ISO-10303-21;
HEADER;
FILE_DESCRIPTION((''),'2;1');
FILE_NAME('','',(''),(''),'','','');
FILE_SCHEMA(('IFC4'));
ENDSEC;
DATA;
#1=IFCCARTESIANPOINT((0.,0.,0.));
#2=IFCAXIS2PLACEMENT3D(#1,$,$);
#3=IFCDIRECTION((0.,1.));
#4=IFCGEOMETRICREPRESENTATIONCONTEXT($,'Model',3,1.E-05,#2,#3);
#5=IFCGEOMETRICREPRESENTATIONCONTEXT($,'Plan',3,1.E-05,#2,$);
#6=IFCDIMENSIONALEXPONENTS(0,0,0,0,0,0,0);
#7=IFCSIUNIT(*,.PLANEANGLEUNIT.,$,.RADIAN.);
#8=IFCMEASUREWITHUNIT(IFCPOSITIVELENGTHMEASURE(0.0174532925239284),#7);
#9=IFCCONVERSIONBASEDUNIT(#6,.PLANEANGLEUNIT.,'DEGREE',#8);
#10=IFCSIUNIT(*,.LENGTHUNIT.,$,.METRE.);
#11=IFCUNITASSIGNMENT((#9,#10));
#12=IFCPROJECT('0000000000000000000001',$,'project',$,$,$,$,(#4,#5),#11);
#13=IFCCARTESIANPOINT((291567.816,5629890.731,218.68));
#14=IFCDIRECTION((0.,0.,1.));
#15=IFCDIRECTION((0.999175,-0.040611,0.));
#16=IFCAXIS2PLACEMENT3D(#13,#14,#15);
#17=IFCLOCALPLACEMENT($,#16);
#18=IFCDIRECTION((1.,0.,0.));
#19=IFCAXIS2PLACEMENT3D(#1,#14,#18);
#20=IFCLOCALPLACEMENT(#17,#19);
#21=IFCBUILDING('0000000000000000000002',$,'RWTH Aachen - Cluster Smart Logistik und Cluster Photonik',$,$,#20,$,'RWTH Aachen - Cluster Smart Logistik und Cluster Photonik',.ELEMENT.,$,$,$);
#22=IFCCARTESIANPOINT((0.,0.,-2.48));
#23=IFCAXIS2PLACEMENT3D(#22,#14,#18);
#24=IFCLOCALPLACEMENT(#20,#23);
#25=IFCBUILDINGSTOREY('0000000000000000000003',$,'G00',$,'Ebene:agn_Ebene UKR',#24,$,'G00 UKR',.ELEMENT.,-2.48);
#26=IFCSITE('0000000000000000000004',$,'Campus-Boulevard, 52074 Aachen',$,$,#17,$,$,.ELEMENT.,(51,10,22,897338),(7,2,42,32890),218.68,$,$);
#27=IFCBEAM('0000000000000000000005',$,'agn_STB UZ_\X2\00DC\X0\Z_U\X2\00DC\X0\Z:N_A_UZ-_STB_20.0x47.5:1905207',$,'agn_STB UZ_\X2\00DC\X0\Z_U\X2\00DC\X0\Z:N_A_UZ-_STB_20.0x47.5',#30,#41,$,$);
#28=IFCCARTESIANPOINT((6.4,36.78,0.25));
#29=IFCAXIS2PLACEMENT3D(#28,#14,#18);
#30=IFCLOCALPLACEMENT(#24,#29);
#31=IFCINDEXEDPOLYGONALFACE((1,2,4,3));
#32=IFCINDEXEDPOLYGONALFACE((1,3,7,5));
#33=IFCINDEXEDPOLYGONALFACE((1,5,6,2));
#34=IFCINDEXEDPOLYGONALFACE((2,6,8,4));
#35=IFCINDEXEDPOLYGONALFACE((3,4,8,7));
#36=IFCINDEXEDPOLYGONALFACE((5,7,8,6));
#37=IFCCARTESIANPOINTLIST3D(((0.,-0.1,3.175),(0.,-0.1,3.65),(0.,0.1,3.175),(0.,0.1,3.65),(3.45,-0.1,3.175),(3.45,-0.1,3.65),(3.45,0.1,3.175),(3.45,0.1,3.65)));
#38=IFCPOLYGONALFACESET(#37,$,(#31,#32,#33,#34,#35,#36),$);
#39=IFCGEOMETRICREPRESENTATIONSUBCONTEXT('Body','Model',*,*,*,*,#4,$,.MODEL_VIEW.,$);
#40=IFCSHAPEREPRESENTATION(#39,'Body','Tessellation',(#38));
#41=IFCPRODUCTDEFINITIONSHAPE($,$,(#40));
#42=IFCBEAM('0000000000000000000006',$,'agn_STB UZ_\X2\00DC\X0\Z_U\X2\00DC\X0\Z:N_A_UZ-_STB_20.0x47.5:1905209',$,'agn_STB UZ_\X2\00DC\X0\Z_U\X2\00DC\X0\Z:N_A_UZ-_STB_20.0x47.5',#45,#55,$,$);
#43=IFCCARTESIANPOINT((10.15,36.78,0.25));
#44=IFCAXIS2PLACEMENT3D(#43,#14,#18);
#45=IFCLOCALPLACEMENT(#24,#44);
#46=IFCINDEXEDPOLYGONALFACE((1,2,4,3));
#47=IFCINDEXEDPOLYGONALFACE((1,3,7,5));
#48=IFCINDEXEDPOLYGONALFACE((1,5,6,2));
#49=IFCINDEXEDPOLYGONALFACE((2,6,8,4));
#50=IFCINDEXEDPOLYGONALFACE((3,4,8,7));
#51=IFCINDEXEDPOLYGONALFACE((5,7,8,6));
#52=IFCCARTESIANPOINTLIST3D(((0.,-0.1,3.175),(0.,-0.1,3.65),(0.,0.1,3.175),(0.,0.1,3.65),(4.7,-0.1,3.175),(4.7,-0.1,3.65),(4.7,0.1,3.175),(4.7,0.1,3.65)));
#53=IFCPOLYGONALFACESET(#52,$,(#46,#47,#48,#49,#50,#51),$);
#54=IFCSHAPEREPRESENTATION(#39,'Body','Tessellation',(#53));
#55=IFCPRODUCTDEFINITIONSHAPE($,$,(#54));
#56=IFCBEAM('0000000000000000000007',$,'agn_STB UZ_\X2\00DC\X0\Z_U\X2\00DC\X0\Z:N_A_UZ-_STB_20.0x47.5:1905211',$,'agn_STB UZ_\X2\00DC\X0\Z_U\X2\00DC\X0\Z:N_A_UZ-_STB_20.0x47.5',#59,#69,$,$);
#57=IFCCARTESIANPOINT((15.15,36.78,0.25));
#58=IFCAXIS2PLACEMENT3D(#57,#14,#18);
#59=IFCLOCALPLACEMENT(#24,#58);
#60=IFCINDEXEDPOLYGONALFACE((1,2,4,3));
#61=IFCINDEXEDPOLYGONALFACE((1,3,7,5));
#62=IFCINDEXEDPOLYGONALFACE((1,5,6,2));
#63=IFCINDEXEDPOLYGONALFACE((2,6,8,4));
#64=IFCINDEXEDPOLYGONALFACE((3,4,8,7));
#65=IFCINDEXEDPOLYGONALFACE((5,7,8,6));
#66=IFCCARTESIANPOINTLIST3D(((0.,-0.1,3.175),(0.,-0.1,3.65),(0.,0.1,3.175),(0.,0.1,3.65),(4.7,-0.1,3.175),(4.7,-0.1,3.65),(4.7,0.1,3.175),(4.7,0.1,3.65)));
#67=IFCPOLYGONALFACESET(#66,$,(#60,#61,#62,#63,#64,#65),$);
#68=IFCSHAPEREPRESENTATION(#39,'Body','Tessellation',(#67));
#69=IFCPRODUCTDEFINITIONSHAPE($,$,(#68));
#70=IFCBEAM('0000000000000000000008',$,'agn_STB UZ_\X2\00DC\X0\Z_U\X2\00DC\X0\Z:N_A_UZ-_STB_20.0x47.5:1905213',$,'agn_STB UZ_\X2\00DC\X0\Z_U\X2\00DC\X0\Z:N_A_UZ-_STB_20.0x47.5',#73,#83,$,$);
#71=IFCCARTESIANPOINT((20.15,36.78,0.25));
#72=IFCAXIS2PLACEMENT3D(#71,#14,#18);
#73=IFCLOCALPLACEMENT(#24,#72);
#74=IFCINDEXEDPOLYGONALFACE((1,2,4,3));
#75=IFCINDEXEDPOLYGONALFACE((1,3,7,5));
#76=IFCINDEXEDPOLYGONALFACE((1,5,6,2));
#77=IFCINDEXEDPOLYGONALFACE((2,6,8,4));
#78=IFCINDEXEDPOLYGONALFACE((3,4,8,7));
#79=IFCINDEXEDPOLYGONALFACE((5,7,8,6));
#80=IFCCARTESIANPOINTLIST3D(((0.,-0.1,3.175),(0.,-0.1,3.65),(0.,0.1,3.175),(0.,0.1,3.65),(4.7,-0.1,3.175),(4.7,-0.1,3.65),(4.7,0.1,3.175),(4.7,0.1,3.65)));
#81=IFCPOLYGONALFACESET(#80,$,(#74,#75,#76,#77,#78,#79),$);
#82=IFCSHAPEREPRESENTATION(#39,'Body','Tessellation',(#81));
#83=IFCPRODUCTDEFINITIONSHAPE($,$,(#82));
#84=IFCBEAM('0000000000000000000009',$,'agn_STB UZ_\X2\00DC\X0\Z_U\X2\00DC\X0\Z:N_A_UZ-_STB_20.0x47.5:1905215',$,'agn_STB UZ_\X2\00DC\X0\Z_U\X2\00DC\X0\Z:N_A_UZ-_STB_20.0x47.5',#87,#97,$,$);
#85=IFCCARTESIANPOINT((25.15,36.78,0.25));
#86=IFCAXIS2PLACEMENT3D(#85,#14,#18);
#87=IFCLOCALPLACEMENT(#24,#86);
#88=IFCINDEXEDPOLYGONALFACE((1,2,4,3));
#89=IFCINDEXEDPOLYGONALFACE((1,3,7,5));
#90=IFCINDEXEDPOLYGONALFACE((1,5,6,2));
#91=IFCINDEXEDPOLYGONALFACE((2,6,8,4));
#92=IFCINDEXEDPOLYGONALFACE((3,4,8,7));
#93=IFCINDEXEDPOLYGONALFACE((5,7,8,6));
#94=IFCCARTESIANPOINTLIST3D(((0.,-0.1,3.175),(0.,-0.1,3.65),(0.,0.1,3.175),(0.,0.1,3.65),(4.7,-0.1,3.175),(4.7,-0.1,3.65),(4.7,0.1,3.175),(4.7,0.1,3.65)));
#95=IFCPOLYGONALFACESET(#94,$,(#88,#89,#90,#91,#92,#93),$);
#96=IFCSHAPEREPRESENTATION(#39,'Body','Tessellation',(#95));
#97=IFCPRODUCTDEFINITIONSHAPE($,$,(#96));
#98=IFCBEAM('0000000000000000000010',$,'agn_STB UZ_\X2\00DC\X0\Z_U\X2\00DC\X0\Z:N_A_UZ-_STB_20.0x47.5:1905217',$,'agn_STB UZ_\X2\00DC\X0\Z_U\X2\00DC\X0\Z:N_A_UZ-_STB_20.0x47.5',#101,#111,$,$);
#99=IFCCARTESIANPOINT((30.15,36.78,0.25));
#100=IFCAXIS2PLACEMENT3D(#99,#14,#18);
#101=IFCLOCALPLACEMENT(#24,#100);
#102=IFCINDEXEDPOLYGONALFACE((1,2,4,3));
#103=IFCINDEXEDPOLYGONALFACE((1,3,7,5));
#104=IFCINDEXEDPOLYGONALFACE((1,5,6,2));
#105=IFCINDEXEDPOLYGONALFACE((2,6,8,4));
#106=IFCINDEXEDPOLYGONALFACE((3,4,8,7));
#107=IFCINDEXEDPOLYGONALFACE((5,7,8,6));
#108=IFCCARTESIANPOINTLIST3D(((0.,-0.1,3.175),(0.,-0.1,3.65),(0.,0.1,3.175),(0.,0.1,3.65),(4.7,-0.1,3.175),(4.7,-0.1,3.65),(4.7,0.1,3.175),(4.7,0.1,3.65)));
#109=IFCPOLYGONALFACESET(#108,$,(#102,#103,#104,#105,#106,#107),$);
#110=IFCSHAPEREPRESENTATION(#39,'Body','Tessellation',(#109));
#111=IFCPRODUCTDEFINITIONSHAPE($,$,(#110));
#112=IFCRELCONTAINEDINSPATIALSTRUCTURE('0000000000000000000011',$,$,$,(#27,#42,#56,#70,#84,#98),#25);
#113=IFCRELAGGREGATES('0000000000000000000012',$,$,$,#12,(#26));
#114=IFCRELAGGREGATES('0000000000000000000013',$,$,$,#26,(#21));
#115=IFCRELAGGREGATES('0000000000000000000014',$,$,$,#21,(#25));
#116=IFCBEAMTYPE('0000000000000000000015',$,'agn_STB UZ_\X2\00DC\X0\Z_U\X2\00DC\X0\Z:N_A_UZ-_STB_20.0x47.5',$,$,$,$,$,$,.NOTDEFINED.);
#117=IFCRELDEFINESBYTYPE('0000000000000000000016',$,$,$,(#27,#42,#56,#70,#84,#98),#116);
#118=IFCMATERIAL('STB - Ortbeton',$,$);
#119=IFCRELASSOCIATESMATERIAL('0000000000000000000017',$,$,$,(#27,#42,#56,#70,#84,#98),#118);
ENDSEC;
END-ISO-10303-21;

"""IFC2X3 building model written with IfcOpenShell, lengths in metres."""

from ifc_helpers import new_model, entity, si_unit, converted_unit, direction, frame, frame_2d, origin, origin_with_axes, place, context, subcontext, project, spatial, rectangle, extrude, material, type_object, element, save


model = new_model("IFC2X3")

# Units and contexts
model_context = context("Model", 3, precision=1e-05, world=origin(), true_north=direction((0.0, 1.0)))
plan_context = context("Plan", 3, precision=1e-05, world=origin())
body_context = subcontext(model_context, "Body", "Model", "MODEL_VIEW")
ifc_project = project(units=[converted_unit("PLANEANGLEUNIT", "DEGREE", entity("IfcPositiveLengthMeasure", 0.0174532925239284), si_unit("PLANEANGLEUNIT", "RADIAN"), dimensions=[0, 0, 0, 0, 0, 0, 0]), si_unit("LENGTHUNIT", "METRE")], contexts=[model_context, plan_context])

# Site, building, storey
site_placement = place(None, frame((291567.816, 5629890.731, 218.68), z_axis=(0.0, 0.0, 1.0), x_axis=(0.999175, -0.040611, 0.0)))
site = spatial("IfcSite", under=ifc_project, at=site_placement, Name="Campus-Boulevard, 52074 Aachen", CompositionType="ELEMENT", RefLatitude=(51, 10, 22, 897338), RefLongitude=(7, 2, 42, 32890), RefElevation=218.68)
building_placement = place(site_placement, origin_with_axes())
building = spatial("IfcBuilding", under=site, at=building_placement, Name="RWTH Aachen - Cluster Smart Logistik und Cluster Photonik", LongName="RWTH Aachen - Cluster Smart Logistik und Cluster Photonik", CompositionType="ELEMENT")
storey_placement = place(building_placement, frame((0.0, 0.0, -2.48), z_axis=(0.0, 0.0, 1.0), x_axis=(1.0, 0.0, 0.0)))
storey = spatial("IfcBuildingStorey", under=building, at=storey_placement, Name="G00", ObjectType="Ebene:agn_Ebene UKR", LongName="G00 UKR", CompositionType="ELEMENT", Elevation=-2.48)

# Beams
ifc_material_1 = material(Name="STB - Ortbeton")
beam_type_1 = type_object("IfcBeamType", Name="agn_STB UZ_ÜZ_UÜZ:N_A_UZ-_STB_20.0x47.5", PredefinedType="NOTDEFINED")
beam_1_placement = place(storey_placement, frame((6.4, 36.78, 0.25), z_axis=(0.0, 0.0, 1.0), x_axis=(1.0, 0.0, 0.0)))
element("IfcBeam", 1, at=beam_1_placement, inside=storey, type_object=beam_type_1, material=ifc_material_1, Name="agn_STB UZ_ÜZ_UÜZ:N_A_UZ-_STB_20.0x47.5:1905207", ObjectType="agn_STB UZ_ÜZ_UÜZ:N_A_UZ-_STB_20.0x47.5", context=body_context, shape_type="SweptSolid", body=[
    extrude(rectangle(XDim=0.475, YDim=0.2, at=frame_2d((0.0, 0.0), x_axis=(1.0, 0.0))), frame((0.0, 0.0, 3.4125), z_axis=(1.0, 0.0, 0.0), x_axis=(0.0, 0.0, -1.0)), (0.0, 0.0, 1.0), 3.45),
])
for number, where, z_axis, x_axis, name in (
    (2, (10.15, 36.78, 0.25), (0.0, 0.0, 1.0), (1.0, 0.0, 0.0), "agn_STB UZ_ÜZ_UÜZ:N_A_UZ-_STB_20.0x47.5:1905209"),
    (3, (15.15, 36.78, 0.25), (0.0, 0.0, 1.0), (1.0, 0.0, 0.0), "agn_STB UZ_ÜZ_UÜZ:N_A_UZ-_STB_20.0x47.5:1905211"),
    (4, (20.15, 36.78, 0.25), (0.0, 0.0, 1.0), (1.0, 0.0, 0.0), "agn_STB UZ_ÜZ_UÜZ:N_A_UZ-_STB_20.0x47.5:1905213"),
    (5, (25.15, 36.78, 0.25), (0.0, 0.0, 1.0), (1.0, 0.0, 0.0), "agn_STB UZ_ÜZ_UÜZ:N_A_UZ-_STB_20.0x47.5:1905215"),
    (6, (30.15, 36.78, 0.25), (0.0, 0.0, 1.0), (1.0, 0.0, 0.0), "agn_STB UZ_ÜZ_UÜZ:N_A_UZ-_STB_20.0x47.5:1905217"),
):
    element("IfcBeam", number, at=place(storey_placement, frame(where, z_axis=z_axis, x_axis=x_axis)), inside=storey, type_object=beam_type_1, material=ifc_material_1, Name=name, ObjectType="agn_STB UZ_ÜZ_UÜZ:N_A_UZ-_STB_20.0x47.5", context=body_context, shape_type="SweptSolid", body=[
        extrude(rectangle(XDim=0.475, YDim=0.2, at=frame_2d((0.0, 0.0), x_axis=(1.0, 0.0))), frame((0.0, 0.0, 3.4125), z_axis=(1.0, 0.0, 0.0), x_axis=(0.0, 0.0, -1.0)), (0.0, 0.0, 1.0), 4.7),
    ])

save(model, "model.ifc")
